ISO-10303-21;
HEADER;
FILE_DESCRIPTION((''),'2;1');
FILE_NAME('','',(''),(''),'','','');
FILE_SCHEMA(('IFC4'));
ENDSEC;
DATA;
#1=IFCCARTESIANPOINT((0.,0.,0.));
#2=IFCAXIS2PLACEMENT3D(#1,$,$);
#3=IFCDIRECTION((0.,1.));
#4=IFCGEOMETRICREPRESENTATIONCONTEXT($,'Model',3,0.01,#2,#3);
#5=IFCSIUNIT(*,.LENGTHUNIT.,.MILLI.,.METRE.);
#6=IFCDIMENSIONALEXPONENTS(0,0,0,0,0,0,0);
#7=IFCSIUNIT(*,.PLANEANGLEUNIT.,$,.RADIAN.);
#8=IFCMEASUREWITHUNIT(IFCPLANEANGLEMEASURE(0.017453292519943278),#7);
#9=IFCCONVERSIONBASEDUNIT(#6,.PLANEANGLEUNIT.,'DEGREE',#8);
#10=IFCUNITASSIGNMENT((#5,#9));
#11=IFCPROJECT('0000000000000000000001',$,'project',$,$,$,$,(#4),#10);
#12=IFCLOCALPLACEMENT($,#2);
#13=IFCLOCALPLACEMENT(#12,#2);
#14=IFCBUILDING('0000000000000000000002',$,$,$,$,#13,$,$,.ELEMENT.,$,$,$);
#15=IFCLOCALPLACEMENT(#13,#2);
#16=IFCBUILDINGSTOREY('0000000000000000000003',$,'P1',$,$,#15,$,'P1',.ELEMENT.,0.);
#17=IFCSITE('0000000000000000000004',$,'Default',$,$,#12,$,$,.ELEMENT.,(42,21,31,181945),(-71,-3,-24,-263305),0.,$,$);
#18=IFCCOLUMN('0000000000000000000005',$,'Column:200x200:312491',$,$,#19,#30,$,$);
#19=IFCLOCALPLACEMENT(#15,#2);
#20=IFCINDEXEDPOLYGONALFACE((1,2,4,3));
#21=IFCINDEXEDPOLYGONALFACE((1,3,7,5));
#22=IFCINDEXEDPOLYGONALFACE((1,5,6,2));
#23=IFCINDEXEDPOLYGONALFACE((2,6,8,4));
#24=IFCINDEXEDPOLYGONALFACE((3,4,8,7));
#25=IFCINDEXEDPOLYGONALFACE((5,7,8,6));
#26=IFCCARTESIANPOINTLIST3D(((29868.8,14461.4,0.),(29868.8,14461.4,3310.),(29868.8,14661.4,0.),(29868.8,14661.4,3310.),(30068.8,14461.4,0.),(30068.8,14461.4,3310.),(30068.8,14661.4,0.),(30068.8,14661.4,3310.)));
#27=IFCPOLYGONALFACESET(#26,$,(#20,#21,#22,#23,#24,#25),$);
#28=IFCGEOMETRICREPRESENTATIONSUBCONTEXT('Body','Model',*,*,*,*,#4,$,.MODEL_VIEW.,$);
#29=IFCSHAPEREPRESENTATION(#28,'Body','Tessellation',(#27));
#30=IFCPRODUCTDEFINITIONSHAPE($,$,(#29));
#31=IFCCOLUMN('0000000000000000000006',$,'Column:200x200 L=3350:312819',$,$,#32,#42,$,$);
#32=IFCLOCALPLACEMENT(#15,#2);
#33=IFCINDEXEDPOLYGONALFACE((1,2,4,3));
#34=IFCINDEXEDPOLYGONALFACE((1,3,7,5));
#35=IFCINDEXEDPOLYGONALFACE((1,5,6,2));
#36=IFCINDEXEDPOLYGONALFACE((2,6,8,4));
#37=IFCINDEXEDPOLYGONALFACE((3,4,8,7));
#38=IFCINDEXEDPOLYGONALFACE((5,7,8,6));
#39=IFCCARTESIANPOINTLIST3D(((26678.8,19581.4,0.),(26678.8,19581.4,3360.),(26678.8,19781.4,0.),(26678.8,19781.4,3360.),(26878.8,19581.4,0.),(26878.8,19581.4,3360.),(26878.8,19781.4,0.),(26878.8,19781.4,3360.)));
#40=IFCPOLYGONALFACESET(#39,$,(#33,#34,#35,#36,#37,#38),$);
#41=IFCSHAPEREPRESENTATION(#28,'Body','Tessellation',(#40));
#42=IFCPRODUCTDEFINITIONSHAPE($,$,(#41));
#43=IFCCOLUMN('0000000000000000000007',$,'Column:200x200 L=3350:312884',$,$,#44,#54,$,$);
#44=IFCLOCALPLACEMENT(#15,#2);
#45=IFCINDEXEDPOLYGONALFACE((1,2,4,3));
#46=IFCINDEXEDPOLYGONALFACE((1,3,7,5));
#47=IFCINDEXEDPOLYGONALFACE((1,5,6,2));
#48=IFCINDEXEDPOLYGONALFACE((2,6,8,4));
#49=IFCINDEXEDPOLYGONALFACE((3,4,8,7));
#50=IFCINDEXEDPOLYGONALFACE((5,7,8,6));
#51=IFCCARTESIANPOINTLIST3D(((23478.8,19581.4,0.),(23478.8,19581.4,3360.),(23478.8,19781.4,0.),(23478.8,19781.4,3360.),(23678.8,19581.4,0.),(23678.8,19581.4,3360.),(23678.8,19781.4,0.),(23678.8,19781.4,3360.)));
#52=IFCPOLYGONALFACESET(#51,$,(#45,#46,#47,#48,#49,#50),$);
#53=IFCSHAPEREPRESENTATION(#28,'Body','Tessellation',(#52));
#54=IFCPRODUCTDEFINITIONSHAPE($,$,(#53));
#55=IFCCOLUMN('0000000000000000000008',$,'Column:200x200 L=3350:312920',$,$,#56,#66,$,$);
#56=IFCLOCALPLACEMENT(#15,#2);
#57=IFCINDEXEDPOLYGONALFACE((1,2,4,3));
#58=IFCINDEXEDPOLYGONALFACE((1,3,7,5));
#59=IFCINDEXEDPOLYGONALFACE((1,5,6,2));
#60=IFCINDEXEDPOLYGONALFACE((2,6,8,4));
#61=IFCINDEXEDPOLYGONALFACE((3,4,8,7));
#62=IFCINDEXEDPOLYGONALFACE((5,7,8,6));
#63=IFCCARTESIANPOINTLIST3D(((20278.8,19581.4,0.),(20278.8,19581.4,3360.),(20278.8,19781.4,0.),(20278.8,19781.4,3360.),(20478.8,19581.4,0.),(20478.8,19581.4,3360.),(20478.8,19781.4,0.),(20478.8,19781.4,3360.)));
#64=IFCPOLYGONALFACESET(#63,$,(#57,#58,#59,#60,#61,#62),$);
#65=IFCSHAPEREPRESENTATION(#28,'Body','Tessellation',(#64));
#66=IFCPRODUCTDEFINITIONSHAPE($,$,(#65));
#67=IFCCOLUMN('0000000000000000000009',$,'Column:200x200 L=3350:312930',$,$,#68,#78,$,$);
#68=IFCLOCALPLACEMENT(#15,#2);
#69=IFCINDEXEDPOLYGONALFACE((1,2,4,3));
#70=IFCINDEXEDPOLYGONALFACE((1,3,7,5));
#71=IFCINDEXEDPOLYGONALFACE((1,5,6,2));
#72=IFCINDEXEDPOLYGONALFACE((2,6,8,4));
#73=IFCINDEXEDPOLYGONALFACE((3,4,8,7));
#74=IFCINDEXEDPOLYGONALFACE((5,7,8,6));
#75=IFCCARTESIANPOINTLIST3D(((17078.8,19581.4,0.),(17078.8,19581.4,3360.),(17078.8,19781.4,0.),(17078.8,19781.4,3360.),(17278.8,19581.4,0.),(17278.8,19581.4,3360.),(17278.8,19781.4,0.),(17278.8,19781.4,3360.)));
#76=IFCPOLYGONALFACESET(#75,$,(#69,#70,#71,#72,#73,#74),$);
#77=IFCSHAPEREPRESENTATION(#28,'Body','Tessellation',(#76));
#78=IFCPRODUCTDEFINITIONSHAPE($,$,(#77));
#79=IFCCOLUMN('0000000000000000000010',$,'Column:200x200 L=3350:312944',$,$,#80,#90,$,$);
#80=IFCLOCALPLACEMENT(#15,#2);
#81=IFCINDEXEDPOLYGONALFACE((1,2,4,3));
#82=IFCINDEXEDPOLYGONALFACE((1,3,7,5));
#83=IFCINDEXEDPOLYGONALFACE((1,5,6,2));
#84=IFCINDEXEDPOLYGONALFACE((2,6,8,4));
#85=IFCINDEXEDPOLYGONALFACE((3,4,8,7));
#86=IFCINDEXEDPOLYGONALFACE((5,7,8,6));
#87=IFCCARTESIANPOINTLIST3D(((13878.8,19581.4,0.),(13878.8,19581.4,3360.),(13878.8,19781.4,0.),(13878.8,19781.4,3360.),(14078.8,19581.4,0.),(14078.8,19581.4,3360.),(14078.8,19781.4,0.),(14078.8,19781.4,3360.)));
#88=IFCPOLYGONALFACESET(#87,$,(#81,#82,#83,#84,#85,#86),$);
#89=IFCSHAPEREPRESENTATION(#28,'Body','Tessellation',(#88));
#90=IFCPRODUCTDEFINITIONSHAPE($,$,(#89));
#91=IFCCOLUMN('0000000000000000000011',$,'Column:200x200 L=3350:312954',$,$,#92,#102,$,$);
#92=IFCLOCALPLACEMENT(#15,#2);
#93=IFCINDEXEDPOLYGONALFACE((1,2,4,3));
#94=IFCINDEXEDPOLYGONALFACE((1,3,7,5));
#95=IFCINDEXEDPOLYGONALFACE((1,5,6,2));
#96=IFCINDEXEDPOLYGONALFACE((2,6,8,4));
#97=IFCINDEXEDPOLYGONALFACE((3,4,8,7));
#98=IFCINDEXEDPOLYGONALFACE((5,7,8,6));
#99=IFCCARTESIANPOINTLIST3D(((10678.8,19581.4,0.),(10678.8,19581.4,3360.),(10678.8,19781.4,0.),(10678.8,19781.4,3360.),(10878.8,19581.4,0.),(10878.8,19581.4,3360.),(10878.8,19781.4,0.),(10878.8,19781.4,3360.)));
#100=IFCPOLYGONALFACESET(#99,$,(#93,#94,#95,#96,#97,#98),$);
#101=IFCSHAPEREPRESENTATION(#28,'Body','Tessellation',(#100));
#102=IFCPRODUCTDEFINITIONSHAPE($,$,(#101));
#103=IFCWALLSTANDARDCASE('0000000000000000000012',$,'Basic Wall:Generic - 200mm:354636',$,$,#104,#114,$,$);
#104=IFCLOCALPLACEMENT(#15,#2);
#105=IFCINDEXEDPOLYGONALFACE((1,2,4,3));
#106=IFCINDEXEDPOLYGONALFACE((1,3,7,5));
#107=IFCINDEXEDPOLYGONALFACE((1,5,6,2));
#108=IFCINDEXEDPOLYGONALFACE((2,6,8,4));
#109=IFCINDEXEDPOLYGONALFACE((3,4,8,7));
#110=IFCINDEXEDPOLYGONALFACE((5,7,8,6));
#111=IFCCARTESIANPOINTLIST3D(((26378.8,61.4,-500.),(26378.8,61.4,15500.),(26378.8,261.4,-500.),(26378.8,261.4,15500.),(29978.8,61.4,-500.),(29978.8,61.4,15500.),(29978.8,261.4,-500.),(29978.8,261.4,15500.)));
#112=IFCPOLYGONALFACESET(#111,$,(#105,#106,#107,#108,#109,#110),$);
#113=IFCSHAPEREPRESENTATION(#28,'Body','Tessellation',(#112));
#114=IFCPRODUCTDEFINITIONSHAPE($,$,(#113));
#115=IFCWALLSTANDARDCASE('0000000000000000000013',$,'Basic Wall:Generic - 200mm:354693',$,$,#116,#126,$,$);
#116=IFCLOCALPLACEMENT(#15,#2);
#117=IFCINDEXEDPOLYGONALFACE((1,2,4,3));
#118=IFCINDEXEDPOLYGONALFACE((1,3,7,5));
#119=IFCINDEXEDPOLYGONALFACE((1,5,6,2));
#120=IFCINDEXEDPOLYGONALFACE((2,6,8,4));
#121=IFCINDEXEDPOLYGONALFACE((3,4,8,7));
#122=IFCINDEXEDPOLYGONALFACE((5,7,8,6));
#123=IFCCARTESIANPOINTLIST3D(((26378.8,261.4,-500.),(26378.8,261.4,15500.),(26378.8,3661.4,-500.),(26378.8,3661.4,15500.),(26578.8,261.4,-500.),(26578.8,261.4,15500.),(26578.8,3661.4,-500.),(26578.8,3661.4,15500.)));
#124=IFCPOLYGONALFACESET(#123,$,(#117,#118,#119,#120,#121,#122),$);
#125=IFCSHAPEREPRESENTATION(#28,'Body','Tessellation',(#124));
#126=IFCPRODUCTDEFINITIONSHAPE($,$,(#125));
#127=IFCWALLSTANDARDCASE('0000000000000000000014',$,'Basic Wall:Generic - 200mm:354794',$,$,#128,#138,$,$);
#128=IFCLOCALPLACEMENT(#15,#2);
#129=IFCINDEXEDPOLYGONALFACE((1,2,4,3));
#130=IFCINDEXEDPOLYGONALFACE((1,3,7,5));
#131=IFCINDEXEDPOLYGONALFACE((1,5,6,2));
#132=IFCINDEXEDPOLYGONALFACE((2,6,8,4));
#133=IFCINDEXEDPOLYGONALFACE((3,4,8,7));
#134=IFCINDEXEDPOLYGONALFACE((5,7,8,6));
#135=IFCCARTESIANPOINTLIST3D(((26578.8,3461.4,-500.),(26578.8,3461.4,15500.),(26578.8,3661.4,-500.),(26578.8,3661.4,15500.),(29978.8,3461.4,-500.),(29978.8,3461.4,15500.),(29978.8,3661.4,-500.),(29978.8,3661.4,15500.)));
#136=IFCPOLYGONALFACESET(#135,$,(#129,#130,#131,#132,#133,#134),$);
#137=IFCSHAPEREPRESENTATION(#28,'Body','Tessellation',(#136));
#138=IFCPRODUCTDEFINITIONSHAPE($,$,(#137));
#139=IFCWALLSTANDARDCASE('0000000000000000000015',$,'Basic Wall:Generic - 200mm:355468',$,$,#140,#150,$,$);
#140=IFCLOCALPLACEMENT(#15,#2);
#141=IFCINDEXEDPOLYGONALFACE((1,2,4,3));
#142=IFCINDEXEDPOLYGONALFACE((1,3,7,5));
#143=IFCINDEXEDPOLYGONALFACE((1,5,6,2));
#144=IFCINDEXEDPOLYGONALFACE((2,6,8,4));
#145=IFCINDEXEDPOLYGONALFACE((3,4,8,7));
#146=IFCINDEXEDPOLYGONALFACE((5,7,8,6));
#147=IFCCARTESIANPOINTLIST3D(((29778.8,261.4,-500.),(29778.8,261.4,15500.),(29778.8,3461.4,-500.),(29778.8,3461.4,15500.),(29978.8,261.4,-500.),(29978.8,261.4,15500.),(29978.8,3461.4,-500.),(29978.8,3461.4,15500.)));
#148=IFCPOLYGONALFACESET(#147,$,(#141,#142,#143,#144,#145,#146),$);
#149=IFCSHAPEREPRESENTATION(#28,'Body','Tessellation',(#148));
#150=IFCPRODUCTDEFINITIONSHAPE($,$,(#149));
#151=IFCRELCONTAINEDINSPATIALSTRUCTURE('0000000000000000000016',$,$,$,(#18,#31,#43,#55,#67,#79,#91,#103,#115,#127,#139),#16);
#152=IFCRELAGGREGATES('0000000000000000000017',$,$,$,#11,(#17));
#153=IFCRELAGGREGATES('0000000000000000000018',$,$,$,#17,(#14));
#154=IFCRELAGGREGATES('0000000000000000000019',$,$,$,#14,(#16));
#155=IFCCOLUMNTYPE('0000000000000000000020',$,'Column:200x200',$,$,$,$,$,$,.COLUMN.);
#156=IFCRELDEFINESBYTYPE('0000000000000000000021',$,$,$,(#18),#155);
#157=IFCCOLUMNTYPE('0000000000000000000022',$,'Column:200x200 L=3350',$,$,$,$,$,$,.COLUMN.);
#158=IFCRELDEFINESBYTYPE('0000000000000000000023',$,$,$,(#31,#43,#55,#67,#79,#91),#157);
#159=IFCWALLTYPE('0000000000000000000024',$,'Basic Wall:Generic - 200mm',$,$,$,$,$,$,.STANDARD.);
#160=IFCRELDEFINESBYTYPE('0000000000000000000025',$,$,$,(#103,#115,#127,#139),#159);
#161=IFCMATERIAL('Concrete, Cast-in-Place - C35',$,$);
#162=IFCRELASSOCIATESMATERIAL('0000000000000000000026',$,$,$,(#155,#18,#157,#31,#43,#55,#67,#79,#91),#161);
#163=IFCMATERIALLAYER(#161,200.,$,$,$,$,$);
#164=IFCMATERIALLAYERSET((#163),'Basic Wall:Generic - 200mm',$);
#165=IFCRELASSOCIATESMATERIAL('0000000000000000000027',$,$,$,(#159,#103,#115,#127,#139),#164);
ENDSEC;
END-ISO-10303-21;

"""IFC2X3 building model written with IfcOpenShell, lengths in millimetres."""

from ifc_helpers import new_model, entity, si_unit, converted_unit, direction, frame, frame_2d, origin, place, context, subcontext, project, spatial, rectangle, extrude, source, transform, mapped, material, layer, layer_set, layer_usage, type_object, type_shapes, element, save


model = new_model("IFC2X3")

# Units and contexts
model_context = context("Model", 3, precision=0.01, world=origin(), true_north=direction((0.0, 1.0)))
body_context = subcontext(model_context, "Body", "Model", "MODEL_VIEW")
ifc_project = project(units=[si_unit("LENGTHUNIT", "METRE", prefix="MILLI"), converted_unit("PLANEANGLEUNIT", "DEGREE", entity("IfcPlaneAngleMeasure", 0.017453292519943278), si_unit("PLANEANGLEUNIT", "RADIAN"), dimensions=[0, 0, 0, 0, 0, 0, 0])], contexts=[model_context])

# Site, building, storey
site_placement = place(None, origin())
site = spatial("IfcSite", under=ifc_project, at=site_placement, Name="Default", CompositionType="ELEMENT", RefLatitude=(42, 21, 31, 181945), RefLongitude=(-71, -3, -24, -263305), RefElevation=0.0)
building_placement = place(site_placement, origin())
building = spatial("IfcBuilding", under=site, at=building_placement, CompositionType="ELEMENT")
storey_placement = place(building_placement, origin())
storey = spatial("IfcBuildingStorey", under=building, at=storey_placement, Name="P1", LongName="P1", CompositionType="ELEMENT", Elevation=0.0)

# Columns
ifc_material = material(Name="Concrete, Cast-in-Place - C35")
column_type_1 = type_object("IfcColumnType", Name="Column:200x200", PredefinedType="COLUMN", material=ifc_material)
shared_shape_1 = source(origin(), body_context, "Body", "SweptSolid", [
    extrude(rectangle(XDim=200.0, YDim=200.0, at=frame_2d((0.0, 0.0), x_axis=(1.0, 0.0))), frame((0.0, 0.0, 0.0), z_axis=(0.0, 0.0, 1.0), x_axis=(-1.0, 0.0, 0.0)), (0.0, 0.0, 1.0), 3310.0),
])
type_shapes(column_type_1, [shared_shape_1])
column_1_placement = place(storey_placement, frame((29968.8, 14561.4, 0.0)))
element("IfcColumn", 1, at=column_1_placement, inside=storey, type_object=column_type_1, material=ifc_material, Name="Column:200x200:312491", context=body_context, shape_type="MappedRepresentation", body=[
    mapped(shared_shape_1, transform((0.0, 0.0, 0.0), scale=1.0)),
])
column_type_2 = type_object("IfcColumnType", Name="Column:200x200 L=3350", PredefinedType="COLUMN", material=ifc_material)
shared_shape_2 = source(origin(), body_context, "Body", "SweptSolid", [
    extrude(rectangle(XDim=200.0, YDim=200.0, at=frame_2d((0.0, 0.0), x_axis=(1.0, 0.0))), frame((0.0, 0.0, 0.0), z_axis=(0.0, 0.0, 1.0), x_axis=(-1.0, 0.0, 0.0)), (0.0, 0.0, 1.0), 3360.0),
])
type_shapes(column_type_2, [shared_shape_2])
for number, where, name in (
    (2, (26778.8, 19681.4, 0.0), "Column:200x200 L=3350:312819"),
    (3, (23578.8, 19681.4, 0.0), "Column:200x200 L=3350:312884"),
    (4, (20378.8, 19681.4, 0.0), "Column:200x200 L=3350:312920"),
    (5, (17178.8, 19681.4, 0.0), "Column:200x200 L=3350:312930"),
    (6, (13978.8, 19681.4, 0.0), "Column:200x200 L=3350:312944"),
    (7, (10778.8, 19681.4, 0.0), "Column:200x200 L=3350:312954"),
):
    element("IfcColumn", number, at=place(storey_placement, frame(where)), inside=storey, type_object=column_type_2, material=ifc_material, Name=name, context=body_context, shape_type="MappedRepresentation", body=[
        mapped(shared_shape_2, transform((0.0, 0.0, 0.0), scale=1.0)),
    ])

# Walls
ifc_layer = layer(ifc_material, 200.0)
ifc_layer_set = layer_set([ifc_layer], Name="Basic Wall:Generic - 200mm")
ifc_layer_usage_1 = layer_usage(ifc_layer_set, "AXIS2", "NEGATIVE", 100.0)
wall_type = type_object("IfcWallType", Name="Basic Wall:Generic - 200mm", PredefinedType="STANDARD", material=ifc_layer_set)
wall_1_placement = place(storey_placement, frame((29978.8, 161.4, -500.0), z_axis=(0.0, 0.0, 1.0), x_axis=(-1.0, 0.0, 0.0)))
element("IfcWallStandardCase", 8, at=wall_1_placement, inside=storey, type_object=wall_type, material=ifc_layer_usage_1, Name="Basic Wall:Generic - 200mm:354636", context=body_context, shape_type="SweptSolid", body=[
    extrude(rectangle(XDim=3600.0, YDim=200.0, at=frame_2d((1800.0, 0.0), x_axis=(-1.0, 0.0))), origin(), (0.0, 0.0, 1.0), 16000.0),
])
ifc_layer_usage_2 = layer_usage(ifc_layer_set, "AXIS2", "NEGATIVE", 100.0)
wall_2_placement = place(storey_placement, frame((26478.8, 261.4, -500.0), z_axis=(0.0, 0.0, 1.0), x_axis=(0.0, 1.0, 0.0)))
element("IfcWallStandardCase", 9, at=wall_2_placement, inside=storey, type_object=wall_type, material=ifc_layer_usage_2, Name="Basic Wall:Generic - 200mm:354693", context=body_context, shape_type="SweptSolid", body=[
    extrude(rectangle(XDim=3400.0, YDim=200.0, at=frame_2d((1700.0, 0.0), x_axis=(-1.0, 0.0))), origin(), (0.0, 0.0, 1.0), 16000.0),
])
ifc_layer_usage_3 = layer_usage(ifc_layer_set, "AXIS2", "NEGATIVE", 100.0)
wall_3_placement = place(storey_placement, frame((26578.8, 3561.4, -500.0)))
element("IfcWallStandardCase", 10, at=wall_3_placement, inside=storey, type_object=wall_type, material=ifc_layer_usage_3, Name="Basic Wall:Generic - 200mm:354794", context=body_context, shape_type="SweptSolid", body=[
    extrude(rectangle(XDim=3400.0, YDim=200.0, at=frame_2d((1700.0, 0.0), x_axis=(-1.0, 0.0))), origin(), (0.0, 0.0, 1.0), 16000.0),
])
ifc_layer_usage_4 = layer_usage(ifc_layer_set, "AXIS2", "NEGATIVE", 100.0)
wall_4_placement = place(storey_placement, frame((29878.8, 3461.4, -500.0), z_axis=(0.0, 0.0, 1.0), x_axis=(0.0, -1.0, 0.0)))
element("IfcWallStandardCase", 11, at=wall_4_placement, inside=storey, type_object=wall_type, material=ifc_layer_usage_4, Name="Basic Wall:Generic - 200mm:355468", context=body_context, shape_type="SweptSolid", body=[
    extrude(rectangle(XDim=3200.0, YDim=200.0, at=frame_2d((1600.0, 0.0), x_axis=(-1.0, 0.0))), origin(), (0.0, 0.0, 1.0), 16000.0),
])

save(model, "model.ifc")
